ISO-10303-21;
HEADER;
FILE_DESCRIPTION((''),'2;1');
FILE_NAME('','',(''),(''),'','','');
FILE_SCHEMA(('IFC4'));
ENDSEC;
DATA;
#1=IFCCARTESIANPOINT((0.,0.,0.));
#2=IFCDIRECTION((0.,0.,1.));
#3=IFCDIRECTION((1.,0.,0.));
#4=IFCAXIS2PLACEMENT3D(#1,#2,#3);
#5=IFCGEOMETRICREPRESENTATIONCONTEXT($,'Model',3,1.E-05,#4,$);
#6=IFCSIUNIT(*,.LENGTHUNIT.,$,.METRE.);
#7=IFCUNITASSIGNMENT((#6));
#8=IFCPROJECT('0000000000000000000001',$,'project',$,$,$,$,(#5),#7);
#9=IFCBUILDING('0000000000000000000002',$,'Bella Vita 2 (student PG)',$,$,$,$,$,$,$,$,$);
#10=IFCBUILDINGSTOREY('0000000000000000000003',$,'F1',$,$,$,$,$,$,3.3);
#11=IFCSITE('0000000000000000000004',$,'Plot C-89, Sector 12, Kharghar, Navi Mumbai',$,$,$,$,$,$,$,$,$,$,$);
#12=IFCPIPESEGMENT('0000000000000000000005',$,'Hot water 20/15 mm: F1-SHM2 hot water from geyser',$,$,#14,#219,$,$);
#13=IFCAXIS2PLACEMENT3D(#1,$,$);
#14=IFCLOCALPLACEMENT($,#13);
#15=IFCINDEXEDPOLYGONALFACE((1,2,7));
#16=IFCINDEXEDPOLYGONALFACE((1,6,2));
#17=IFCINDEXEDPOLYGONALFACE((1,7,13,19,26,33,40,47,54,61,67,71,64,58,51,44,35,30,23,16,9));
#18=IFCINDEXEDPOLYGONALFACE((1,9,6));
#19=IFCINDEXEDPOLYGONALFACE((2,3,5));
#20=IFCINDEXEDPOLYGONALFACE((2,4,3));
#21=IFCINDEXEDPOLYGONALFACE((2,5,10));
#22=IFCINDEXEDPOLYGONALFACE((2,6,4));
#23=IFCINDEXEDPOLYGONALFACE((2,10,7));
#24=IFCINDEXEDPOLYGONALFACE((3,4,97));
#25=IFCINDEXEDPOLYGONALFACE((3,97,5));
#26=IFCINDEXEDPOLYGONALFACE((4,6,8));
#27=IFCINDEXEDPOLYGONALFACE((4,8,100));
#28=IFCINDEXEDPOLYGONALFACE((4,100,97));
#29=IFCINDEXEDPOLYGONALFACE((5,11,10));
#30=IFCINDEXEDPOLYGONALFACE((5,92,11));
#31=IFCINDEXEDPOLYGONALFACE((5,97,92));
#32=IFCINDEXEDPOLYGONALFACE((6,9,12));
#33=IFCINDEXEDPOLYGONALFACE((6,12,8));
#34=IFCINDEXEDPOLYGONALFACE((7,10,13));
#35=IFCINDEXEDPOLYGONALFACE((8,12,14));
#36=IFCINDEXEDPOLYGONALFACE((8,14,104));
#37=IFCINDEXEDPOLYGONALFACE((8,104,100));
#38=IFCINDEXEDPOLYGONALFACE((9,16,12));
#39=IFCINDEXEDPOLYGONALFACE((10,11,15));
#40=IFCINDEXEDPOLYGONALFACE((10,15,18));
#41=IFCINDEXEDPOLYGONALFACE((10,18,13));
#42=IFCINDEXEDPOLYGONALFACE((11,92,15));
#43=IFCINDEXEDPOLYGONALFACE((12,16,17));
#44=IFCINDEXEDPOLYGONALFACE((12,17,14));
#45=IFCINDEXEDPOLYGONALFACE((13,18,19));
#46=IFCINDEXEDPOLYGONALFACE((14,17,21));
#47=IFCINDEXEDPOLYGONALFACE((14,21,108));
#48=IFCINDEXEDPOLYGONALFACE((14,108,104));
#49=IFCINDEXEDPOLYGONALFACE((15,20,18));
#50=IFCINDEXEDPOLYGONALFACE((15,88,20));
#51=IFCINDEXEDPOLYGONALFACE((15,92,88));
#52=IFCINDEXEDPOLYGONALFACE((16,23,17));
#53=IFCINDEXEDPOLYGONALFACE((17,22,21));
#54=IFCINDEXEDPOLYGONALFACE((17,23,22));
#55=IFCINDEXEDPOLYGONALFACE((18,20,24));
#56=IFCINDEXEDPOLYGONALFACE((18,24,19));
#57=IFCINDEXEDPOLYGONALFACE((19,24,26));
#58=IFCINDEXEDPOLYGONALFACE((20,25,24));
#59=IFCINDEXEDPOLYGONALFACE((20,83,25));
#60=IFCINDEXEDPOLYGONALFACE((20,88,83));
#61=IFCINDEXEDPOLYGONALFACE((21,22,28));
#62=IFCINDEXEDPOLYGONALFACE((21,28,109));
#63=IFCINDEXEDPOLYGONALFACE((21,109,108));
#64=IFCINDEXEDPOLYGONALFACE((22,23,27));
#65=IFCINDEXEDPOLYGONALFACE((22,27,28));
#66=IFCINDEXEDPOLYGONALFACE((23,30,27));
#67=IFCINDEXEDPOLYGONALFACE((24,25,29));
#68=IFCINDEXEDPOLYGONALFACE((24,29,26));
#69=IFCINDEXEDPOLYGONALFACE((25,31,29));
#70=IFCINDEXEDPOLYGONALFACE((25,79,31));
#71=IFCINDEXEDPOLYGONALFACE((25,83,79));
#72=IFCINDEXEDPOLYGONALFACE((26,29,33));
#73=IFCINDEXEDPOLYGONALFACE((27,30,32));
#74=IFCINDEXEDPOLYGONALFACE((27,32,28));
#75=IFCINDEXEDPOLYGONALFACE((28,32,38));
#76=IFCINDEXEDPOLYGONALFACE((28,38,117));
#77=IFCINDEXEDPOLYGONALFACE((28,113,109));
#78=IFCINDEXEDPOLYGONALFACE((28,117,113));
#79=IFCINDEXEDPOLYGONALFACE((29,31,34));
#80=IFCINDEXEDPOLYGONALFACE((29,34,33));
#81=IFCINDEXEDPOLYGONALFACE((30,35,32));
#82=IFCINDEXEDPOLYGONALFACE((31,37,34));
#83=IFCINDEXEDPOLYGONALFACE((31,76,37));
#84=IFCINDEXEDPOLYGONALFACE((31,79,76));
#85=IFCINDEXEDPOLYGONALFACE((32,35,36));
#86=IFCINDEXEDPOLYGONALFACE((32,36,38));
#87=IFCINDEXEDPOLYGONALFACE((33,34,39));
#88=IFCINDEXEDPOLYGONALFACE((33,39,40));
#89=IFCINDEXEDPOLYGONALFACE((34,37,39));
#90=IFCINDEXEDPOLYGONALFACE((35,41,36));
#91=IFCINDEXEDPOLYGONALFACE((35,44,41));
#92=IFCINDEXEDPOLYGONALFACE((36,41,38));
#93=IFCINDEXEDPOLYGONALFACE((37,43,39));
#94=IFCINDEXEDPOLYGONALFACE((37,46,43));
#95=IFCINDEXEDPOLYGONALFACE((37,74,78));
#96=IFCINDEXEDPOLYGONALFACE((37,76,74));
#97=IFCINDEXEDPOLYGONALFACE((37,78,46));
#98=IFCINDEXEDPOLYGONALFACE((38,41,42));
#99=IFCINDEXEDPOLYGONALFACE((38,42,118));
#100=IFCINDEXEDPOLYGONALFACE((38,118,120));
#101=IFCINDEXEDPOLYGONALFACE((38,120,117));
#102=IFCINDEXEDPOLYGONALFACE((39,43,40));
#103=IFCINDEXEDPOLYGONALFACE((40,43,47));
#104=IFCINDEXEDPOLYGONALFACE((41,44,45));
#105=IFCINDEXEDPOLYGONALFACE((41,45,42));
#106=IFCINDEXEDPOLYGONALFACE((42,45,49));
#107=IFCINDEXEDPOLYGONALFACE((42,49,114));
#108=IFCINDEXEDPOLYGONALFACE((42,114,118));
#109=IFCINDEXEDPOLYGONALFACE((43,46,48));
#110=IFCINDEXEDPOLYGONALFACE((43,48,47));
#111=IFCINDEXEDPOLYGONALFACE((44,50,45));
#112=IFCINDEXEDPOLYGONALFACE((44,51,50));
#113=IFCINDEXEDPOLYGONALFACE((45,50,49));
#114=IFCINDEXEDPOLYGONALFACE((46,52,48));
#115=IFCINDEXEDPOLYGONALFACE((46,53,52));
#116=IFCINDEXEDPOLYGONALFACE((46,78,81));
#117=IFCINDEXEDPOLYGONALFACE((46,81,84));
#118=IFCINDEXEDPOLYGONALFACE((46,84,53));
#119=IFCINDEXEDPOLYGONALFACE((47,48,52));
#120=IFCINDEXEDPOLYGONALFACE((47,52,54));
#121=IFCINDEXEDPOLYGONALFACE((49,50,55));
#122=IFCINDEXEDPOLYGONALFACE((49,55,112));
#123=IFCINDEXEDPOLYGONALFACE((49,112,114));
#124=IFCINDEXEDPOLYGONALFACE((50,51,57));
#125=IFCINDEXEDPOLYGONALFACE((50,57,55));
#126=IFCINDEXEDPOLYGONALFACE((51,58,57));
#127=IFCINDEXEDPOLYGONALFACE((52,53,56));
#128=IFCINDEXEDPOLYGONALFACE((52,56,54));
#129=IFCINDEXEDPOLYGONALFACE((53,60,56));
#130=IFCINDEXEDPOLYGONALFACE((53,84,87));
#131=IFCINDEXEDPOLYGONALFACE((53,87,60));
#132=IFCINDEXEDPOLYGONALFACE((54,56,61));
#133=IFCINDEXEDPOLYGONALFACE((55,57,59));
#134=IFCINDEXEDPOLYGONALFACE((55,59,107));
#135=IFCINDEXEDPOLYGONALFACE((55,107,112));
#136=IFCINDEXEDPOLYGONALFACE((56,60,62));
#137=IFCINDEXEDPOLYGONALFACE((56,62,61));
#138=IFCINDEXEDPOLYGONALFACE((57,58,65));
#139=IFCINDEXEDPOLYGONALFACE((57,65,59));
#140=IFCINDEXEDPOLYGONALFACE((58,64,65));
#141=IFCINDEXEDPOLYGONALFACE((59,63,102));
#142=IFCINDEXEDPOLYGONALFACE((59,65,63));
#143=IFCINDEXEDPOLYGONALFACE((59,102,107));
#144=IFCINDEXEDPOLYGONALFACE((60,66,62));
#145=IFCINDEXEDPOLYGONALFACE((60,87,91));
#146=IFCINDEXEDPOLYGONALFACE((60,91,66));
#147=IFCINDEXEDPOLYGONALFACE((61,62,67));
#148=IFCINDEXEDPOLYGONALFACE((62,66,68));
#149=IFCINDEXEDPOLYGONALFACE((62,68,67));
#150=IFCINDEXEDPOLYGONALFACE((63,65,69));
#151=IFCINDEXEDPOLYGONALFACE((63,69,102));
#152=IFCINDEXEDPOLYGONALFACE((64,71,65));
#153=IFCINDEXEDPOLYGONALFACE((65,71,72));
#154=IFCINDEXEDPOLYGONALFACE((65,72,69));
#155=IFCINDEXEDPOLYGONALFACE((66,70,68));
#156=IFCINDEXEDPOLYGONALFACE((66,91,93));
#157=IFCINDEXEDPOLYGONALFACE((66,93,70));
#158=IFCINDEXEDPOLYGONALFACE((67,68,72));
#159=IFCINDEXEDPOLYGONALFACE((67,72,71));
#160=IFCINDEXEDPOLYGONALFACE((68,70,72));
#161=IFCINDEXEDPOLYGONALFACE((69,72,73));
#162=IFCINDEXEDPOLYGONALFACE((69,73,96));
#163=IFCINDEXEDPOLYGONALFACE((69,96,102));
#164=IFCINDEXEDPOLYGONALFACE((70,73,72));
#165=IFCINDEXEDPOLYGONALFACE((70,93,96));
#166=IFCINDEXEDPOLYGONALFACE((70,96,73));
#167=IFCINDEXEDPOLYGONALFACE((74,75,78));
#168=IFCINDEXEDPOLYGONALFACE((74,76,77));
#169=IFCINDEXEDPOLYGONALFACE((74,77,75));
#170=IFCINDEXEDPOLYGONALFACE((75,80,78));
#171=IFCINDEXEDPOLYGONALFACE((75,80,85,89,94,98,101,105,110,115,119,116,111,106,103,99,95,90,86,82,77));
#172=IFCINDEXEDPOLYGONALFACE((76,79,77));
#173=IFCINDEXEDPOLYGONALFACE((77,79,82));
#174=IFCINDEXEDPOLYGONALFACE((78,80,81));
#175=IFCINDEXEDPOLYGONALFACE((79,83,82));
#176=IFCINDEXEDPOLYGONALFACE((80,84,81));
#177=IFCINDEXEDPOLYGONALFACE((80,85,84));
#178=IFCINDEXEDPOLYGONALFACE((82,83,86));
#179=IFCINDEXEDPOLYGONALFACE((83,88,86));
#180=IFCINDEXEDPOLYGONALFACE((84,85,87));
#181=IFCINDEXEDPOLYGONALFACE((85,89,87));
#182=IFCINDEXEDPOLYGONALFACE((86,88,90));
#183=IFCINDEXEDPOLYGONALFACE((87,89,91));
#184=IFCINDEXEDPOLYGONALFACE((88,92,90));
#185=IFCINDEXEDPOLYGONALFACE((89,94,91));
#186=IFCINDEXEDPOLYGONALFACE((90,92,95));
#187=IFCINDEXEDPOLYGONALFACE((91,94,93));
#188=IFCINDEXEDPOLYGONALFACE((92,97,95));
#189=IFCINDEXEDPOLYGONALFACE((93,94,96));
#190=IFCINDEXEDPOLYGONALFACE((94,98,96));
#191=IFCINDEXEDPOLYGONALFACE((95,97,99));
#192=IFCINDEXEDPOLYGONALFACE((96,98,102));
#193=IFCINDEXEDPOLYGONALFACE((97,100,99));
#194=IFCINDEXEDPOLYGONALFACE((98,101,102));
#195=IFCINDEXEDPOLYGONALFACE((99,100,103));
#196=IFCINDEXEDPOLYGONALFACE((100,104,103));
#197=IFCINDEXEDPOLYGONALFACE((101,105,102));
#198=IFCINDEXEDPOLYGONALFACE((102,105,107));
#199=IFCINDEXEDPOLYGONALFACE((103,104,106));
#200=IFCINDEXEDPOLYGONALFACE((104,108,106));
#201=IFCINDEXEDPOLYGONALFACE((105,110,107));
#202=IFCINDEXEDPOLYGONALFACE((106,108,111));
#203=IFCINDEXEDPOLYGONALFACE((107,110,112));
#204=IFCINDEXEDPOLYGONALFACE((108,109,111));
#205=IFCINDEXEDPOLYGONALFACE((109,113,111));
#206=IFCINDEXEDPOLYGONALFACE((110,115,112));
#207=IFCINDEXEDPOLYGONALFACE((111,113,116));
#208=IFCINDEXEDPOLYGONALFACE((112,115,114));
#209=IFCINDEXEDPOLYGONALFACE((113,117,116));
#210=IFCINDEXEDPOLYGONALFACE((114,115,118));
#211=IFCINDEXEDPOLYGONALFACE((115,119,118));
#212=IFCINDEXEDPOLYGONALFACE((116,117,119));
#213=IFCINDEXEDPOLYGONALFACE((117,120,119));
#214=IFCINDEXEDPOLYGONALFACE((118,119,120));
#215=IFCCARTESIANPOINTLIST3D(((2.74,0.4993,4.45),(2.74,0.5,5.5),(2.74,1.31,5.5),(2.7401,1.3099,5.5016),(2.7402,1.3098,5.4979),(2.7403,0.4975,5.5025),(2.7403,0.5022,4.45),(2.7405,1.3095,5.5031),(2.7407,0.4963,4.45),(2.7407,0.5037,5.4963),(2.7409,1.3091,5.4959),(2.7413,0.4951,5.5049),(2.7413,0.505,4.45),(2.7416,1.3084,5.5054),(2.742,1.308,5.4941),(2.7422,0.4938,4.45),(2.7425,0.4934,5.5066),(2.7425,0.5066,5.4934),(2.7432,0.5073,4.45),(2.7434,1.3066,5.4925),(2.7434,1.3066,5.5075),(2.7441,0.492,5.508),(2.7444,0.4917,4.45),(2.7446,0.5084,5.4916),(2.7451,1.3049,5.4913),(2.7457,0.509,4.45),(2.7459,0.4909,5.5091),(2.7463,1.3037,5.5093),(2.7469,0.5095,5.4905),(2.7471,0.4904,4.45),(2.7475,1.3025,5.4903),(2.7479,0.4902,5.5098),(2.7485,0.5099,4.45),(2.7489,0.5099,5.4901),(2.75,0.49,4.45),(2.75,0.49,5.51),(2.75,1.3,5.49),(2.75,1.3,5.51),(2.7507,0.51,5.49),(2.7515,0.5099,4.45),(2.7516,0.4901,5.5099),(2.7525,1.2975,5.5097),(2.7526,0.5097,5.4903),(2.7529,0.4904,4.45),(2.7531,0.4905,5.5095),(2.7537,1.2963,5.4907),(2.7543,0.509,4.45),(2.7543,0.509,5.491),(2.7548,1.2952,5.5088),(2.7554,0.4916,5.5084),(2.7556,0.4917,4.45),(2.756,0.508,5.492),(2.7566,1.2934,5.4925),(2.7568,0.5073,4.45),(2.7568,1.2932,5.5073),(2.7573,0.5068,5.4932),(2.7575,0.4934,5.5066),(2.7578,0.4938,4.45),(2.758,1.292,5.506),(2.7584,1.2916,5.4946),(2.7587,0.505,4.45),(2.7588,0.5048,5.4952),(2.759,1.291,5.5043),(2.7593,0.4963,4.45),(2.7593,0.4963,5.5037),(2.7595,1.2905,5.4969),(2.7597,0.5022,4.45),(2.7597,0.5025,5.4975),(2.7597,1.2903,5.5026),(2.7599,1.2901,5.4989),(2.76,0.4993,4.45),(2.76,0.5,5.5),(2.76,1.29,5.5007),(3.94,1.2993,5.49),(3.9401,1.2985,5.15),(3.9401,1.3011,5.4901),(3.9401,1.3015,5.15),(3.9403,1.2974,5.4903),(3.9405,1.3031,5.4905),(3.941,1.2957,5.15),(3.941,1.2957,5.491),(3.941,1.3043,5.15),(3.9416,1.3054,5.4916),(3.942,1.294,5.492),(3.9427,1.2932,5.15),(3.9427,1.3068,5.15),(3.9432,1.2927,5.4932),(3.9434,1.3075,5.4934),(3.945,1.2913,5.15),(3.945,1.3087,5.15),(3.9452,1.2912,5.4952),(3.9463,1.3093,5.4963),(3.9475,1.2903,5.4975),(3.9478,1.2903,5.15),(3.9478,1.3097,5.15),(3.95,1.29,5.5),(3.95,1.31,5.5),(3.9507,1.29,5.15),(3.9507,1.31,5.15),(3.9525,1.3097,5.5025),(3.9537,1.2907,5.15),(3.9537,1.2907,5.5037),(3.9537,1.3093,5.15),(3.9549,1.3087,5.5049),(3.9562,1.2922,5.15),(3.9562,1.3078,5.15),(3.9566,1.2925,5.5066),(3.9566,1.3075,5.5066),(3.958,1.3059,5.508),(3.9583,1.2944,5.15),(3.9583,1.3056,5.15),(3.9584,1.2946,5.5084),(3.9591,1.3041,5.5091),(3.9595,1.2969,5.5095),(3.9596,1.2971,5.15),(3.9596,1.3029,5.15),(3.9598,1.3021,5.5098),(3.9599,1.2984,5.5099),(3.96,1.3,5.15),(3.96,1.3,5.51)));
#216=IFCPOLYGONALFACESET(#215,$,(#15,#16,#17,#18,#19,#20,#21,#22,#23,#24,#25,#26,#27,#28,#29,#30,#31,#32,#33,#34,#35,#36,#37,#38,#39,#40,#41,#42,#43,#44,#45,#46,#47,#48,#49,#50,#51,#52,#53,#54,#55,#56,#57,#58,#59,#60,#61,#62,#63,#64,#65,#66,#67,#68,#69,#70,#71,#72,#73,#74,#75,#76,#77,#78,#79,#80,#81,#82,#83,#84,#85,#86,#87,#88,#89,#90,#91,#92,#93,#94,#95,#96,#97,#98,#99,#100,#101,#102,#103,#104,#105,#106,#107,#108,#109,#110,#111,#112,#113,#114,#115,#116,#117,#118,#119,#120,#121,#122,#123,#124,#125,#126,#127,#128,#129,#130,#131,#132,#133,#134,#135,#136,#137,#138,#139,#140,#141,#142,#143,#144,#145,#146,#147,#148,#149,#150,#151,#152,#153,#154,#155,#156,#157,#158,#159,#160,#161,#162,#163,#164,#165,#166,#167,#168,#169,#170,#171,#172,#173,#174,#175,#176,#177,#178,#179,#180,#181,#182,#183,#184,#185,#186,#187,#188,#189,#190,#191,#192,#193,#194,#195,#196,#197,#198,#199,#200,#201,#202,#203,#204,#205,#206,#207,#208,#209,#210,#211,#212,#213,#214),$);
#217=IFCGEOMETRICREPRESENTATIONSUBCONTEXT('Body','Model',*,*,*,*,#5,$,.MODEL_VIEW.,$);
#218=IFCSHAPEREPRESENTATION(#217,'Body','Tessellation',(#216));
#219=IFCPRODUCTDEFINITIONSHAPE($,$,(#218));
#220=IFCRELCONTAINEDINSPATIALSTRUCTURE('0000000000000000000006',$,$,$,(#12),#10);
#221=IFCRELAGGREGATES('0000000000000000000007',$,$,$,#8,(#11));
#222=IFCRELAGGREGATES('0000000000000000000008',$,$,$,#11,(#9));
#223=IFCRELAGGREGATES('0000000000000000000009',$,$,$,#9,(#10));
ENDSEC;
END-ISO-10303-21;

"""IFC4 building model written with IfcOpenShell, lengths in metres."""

from ifc_helpers import new_model, entity, si_unit, origin, origin_with_axes, place, context, subcontext, project, spatial, element, save


model = new_model("IFC4")

# Units and contexts
model_context = context("Model", 3, precision=1e-05, world=origin_with_axes())
body_context = subcontext(model_context, "Body", "Model", "MODEL_VIEW")
ifc_project = project(units=[si_unit("LENGTHUNIT", "METRE")], contexts=[model_context])

# Site, building, storey
site = spatial("IfcSite", under=ifc_project, Name="Plot C-89, Sector 12, Kharghar, Navi Mumbai")
building = spatial("IfcBuilding", under=site, Name="Bella Vita 2 (student PG)")
storey = spatial("IfcBuildingStorey", under=building, Name="F1", Elevation=3.3)

# Pipe segment
pipe_segment_1_placement = place(None, origin())
element("IfcPipeSegment", 1, at=pipe_segment_1_placement, inside=storey, Name="Hot water 20/15 mm: F1-SHM2 hot water from geyser", context=body_context, shape_type="AdvancedSweptSolid", body=[
    entity("IfcSweptDiskSolid", entity("IfcPolyline", [entity("IfcCartesianPoint", [3.95, 1.3, 5.15]), entity("IfcCartesianPoint", [3.95, 1.3, 5.5]), entity("IfcCartesianPoint", [2.75, 1.3, 5.5]), entity("IfcCartesianPoint", [2.75, 0.5, 5.5]), entity("IfcCartesianPoint", [2.75, 0.5, 4.45])]), 0.01),
])

save(model, "model.ifc")
